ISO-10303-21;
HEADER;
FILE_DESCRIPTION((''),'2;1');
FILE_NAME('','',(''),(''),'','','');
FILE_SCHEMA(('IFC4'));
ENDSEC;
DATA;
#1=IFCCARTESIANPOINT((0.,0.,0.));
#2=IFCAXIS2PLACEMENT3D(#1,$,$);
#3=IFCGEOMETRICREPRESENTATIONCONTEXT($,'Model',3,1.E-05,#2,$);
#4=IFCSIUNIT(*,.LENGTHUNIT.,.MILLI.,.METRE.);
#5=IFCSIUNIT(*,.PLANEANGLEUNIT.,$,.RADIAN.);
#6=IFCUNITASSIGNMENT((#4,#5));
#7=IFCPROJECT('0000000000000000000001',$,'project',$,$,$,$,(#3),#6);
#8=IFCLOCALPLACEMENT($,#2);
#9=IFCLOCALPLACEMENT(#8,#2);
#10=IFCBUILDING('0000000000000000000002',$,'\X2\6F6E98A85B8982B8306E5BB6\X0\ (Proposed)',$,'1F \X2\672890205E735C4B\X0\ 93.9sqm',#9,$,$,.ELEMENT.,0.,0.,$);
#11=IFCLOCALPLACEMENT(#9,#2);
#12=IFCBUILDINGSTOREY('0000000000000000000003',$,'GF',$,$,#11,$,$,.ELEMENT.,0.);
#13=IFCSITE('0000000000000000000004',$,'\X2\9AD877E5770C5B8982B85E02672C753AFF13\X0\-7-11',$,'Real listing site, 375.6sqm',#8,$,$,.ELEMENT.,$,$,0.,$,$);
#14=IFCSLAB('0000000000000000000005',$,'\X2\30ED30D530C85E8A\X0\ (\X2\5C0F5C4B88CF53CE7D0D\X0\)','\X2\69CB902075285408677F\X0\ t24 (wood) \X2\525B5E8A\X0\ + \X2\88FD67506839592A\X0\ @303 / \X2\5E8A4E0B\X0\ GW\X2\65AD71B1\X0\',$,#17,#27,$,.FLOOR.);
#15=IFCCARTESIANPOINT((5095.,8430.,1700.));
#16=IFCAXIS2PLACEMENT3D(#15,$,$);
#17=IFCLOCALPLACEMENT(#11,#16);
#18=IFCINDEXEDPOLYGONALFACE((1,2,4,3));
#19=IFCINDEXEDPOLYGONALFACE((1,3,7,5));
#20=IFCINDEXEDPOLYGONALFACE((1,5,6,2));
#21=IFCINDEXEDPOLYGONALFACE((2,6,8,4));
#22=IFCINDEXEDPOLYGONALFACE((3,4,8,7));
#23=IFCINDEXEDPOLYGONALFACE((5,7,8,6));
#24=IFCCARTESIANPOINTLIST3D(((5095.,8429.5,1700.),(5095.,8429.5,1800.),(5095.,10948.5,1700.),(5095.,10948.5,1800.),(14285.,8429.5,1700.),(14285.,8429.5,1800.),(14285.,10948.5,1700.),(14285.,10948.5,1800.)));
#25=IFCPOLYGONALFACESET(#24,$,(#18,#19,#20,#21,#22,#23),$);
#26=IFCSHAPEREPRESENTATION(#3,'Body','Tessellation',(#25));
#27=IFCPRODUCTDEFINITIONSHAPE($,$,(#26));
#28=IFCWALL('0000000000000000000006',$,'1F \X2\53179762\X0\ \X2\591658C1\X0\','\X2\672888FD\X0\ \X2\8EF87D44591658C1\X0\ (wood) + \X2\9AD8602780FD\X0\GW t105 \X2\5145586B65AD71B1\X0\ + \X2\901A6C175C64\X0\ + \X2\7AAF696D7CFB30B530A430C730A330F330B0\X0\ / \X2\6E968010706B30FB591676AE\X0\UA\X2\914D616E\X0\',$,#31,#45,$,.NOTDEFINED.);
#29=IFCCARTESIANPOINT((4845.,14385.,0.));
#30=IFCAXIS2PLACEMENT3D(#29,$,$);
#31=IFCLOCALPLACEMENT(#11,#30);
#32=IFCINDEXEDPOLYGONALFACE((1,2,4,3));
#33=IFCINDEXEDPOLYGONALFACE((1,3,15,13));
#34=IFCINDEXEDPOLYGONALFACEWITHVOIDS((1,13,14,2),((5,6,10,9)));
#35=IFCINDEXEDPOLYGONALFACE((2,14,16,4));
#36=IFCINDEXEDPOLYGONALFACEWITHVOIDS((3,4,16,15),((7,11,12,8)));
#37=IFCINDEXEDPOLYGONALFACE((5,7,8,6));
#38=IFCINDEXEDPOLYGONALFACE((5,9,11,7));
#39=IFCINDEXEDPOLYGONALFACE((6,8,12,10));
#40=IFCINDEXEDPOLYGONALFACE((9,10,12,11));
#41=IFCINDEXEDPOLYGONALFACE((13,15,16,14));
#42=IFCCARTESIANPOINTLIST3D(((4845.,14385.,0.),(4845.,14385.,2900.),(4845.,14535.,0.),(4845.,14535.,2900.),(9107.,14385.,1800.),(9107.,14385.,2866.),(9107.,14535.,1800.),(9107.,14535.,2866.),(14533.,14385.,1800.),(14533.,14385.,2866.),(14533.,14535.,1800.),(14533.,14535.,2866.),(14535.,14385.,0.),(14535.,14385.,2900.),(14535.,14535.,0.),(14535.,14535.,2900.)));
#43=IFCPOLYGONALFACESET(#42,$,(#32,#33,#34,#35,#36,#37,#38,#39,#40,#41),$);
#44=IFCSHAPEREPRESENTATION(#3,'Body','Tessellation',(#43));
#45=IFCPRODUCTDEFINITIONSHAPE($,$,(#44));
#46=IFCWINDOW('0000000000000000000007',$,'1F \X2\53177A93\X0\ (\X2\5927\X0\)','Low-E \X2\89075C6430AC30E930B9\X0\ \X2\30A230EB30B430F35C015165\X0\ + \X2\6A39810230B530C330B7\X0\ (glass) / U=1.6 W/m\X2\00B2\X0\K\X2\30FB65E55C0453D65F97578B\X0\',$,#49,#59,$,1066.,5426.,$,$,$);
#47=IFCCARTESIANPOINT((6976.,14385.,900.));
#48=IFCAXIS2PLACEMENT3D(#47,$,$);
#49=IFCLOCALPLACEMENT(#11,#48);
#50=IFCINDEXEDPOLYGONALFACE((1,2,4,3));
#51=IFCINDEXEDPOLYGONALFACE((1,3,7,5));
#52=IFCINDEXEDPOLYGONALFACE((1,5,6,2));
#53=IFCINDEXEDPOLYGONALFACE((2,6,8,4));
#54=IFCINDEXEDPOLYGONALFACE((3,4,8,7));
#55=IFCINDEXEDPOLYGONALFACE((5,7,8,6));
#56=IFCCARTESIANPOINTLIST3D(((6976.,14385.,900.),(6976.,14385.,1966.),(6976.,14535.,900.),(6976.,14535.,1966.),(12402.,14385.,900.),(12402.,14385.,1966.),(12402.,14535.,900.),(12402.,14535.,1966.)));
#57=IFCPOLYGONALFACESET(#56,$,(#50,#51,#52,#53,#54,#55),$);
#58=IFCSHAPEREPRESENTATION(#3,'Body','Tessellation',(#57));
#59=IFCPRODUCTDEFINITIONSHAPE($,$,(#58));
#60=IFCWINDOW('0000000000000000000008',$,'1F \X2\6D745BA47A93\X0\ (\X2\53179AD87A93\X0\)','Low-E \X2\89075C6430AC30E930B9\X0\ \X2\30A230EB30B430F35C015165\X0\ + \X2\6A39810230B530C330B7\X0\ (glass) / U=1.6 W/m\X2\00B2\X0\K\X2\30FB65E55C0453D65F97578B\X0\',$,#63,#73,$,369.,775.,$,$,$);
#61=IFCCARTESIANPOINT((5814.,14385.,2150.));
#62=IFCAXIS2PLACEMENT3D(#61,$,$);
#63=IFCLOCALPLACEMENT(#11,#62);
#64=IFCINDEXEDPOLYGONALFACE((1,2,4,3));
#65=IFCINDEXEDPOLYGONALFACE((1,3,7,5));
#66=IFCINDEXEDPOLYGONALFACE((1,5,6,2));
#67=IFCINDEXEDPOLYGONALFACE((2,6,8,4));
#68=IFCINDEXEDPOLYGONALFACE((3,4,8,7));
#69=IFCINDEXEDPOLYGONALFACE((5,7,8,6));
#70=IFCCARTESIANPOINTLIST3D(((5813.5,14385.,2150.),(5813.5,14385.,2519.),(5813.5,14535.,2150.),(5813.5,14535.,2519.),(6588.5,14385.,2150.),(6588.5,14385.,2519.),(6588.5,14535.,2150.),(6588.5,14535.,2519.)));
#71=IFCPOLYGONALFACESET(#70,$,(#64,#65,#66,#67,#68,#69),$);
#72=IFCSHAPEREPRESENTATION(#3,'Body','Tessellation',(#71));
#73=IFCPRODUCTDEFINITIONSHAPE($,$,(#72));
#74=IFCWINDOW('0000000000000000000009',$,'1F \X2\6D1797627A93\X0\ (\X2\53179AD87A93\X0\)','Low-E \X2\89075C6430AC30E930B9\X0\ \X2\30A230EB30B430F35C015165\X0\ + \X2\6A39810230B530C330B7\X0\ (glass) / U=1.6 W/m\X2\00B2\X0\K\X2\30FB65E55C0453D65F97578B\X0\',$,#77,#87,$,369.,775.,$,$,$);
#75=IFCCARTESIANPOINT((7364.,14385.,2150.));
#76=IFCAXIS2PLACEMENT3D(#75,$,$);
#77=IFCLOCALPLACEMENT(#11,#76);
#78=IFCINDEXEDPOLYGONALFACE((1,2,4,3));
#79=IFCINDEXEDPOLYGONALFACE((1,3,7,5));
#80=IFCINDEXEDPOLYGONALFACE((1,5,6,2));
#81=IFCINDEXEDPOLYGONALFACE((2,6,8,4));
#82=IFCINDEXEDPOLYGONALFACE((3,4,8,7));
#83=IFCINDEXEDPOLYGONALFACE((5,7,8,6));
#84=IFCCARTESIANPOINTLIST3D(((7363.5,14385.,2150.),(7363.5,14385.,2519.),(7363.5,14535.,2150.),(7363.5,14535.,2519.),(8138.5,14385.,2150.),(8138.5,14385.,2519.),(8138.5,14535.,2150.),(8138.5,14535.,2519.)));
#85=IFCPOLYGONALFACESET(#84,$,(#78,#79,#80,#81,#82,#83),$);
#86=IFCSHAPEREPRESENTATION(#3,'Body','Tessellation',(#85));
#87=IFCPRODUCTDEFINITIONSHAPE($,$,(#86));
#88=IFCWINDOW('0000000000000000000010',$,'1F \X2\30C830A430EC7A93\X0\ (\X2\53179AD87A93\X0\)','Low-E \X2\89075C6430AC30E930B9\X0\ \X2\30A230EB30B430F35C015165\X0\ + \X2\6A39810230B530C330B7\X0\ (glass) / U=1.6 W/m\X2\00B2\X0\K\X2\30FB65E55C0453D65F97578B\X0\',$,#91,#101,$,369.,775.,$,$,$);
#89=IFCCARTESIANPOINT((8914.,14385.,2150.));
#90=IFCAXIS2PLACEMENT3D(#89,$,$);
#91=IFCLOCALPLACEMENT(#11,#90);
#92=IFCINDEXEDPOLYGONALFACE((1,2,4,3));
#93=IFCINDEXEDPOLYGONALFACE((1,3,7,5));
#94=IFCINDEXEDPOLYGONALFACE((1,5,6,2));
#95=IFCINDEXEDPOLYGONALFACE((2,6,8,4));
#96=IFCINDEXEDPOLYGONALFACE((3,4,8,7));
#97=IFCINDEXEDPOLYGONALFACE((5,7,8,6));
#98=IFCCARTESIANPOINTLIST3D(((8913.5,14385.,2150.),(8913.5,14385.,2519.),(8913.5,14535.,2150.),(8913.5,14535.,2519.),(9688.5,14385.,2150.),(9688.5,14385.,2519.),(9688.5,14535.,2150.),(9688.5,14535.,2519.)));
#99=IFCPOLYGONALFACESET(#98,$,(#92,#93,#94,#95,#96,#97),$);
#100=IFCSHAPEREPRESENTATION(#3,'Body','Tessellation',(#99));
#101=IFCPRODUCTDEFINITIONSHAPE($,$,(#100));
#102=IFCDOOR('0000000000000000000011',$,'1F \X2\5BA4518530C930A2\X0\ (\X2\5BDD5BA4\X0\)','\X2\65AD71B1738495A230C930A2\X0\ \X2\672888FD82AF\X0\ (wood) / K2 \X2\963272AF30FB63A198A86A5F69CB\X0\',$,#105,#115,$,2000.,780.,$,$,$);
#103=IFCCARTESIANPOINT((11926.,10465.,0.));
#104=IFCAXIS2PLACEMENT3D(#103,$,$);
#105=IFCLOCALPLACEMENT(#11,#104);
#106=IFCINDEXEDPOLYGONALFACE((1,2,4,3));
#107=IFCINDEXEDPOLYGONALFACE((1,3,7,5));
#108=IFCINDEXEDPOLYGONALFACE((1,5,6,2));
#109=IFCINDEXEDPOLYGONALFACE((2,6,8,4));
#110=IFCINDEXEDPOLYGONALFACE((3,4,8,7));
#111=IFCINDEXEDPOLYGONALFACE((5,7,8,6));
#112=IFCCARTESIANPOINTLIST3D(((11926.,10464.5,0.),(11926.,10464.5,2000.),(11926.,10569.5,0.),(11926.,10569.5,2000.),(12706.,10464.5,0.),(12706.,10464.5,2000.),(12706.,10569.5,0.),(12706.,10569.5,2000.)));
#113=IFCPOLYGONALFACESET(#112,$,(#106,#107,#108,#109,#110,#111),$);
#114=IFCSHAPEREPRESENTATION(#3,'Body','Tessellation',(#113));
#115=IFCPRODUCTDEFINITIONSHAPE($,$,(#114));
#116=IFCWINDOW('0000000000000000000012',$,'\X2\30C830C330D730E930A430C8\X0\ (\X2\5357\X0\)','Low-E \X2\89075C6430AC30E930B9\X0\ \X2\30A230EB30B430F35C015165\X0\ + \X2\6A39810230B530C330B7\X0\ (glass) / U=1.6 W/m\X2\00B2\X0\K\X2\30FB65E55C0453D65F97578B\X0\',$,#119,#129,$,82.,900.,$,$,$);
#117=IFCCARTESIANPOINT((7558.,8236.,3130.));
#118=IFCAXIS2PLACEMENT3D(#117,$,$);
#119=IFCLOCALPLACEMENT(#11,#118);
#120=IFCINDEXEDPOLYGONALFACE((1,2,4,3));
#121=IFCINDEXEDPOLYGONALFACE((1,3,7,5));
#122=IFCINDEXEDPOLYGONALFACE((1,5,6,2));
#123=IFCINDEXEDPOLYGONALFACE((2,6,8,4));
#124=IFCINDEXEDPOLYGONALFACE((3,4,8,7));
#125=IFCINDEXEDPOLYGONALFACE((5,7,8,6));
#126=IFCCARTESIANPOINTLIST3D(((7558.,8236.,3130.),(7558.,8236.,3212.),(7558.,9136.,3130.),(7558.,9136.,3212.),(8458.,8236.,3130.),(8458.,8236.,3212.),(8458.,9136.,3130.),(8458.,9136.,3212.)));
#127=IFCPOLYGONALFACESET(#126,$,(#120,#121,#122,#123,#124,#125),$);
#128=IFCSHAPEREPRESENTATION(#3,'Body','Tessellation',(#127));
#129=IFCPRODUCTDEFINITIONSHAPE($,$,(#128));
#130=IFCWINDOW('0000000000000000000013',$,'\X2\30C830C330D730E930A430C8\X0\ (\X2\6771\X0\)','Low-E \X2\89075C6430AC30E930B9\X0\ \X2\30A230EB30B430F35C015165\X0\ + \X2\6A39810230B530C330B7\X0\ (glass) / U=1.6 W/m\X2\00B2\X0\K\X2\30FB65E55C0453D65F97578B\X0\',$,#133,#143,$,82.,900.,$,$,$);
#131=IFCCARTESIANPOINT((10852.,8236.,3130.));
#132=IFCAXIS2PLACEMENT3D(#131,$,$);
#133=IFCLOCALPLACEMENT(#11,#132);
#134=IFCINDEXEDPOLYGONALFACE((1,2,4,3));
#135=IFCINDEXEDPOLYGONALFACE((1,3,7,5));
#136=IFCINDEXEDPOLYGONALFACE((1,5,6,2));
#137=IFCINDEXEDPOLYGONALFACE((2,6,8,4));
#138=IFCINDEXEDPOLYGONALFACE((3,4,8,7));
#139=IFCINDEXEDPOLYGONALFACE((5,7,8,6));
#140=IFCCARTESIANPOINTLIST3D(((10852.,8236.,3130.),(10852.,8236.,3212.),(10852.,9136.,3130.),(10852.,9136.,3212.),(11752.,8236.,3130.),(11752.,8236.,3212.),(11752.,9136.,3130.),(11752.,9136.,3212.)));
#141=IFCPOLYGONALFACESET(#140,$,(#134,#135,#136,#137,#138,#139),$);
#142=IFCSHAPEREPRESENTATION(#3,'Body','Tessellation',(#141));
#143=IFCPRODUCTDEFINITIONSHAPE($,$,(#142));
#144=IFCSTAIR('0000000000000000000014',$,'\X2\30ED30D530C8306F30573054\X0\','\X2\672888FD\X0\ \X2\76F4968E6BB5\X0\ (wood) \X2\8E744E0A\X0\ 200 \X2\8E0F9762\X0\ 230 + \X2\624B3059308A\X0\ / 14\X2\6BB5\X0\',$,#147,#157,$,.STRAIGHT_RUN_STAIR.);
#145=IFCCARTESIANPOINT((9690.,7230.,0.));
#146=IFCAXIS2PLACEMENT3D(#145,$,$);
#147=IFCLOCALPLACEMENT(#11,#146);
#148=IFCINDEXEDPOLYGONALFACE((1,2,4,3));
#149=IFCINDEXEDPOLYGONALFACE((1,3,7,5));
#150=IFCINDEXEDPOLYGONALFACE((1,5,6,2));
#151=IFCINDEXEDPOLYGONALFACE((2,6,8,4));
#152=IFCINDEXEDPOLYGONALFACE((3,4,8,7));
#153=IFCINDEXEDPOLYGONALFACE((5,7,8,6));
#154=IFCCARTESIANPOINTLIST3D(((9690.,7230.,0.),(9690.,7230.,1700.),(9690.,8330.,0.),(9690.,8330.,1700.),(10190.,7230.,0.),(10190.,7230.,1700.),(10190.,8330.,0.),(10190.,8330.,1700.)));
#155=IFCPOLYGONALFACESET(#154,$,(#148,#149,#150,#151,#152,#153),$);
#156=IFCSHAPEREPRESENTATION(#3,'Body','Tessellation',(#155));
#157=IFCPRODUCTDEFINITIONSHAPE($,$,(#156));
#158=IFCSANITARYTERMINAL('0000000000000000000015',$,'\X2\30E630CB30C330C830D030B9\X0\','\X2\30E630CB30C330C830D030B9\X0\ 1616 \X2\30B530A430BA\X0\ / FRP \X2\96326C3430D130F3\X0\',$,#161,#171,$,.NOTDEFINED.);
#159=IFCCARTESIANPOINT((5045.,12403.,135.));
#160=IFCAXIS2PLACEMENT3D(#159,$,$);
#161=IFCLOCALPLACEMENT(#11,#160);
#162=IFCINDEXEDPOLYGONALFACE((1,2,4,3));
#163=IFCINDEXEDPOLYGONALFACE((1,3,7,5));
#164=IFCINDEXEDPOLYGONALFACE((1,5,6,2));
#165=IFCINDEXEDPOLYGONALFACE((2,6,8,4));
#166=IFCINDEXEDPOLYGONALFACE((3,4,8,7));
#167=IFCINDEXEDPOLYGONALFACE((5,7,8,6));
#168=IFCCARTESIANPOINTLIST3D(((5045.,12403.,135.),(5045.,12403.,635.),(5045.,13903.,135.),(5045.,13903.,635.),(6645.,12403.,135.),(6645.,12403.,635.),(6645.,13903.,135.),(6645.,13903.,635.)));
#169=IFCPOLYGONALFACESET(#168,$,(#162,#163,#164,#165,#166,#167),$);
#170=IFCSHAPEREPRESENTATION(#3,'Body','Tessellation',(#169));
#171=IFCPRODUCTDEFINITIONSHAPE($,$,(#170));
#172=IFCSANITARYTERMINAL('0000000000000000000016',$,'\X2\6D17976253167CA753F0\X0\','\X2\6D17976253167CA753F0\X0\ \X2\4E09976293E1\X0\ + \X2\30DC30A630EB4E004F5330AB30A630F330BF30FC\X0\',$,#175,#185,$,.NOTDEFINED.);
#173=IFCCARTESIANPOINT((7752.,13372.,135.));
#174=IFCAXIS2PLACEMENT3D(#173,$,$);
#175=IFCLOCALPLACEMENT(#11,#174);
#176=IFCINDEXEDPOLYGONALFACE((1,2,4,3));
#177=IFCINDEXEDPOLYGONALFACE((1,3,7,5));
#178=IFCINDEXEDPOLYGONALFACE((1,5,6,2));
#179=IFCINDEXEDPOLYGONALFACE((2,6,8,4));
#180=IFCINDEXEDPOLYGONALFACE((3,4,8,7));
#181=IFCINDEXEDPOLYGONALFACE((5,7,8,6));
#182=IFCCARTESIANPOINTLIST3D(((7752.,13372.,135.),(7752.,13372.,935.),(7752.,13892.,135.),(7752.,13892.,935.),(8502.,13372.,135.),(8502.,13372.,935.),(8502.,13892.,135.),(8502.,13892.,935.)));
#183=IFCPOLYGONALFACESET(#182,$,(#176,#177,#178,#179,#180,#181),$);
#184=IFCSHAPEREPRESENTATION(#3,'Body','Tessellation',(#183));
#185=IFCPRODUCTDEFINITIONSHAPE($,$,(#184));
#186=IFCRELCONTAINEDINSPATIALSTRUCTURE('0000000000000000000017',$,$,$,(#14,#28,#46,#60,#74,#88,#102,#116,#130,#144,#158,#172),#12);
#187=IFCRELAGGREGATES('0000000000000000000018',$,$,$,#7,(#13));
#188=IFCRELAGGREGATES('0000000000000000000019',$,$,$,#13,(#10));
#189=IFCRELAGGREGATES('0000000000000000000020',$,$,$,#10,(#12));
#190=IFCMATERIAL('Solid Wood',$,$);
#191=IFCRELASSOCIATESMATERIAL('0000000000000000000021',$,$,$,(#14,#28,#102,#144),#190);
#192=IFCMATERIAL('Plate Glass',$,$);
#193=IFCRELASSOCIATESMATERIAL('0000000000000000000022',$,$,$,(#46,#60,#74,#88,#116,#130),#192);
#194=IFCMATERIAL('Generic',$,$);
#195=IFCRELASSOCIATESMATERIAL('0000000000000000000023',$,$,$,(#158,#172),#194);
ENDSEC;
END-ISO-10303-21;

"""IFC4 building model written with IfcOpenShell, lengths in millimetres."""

from ifc_helpers import new_model, si_unit, frame, frame_2d, origin, place, context, project, spatial, rectangle, extrude, material, element, fill, save


model = new_model("IFC4")

# Units and contexts
model_context = context("Model", 3, precision=1e-05, world=origin())
ifc_project = project(units=[si_unit("LENGTHUNIT", "METRE", prefix="MILLI"), si_unit("PLANEANGLEUNIT", "RADIAN")], contexts=[model_context])

# Site, building, storey
site_placement = place(None, origin())
site = spatial("IfcSite", under=ifc_project, at=site_placement, Name="高知県安芸市本町３-7-11", ObjectType="Real listing site, 375.6sqm", CompositionType="ELEMENT", RefElevation=0.0)
building_placement = place(site_placement, origin())
building = spatial("IfcBuilding", under=site, at=building_placement, Name="潮風安芸の家 (Proposed)", ObjectType="1F 木造平屋 93.9sqm", CompositionType="ELEMENT", ElevationOfRefHeight=0.0, ElevationOfTerrain=0.0)
storey_placement = place(building_placement, origin())
storey = spatial("IfcBuildingStorey", under=building, at=storey_placement, Name="GF", CompositionType="ELEMENT", Elevation=0.0)

# Slab
ifc_material_1 = material(Name="Solid Wood")
slab_placement = place(storey_placement, frame((5095.0, 8430.0, 1700.0)))
element("IfcSlab", 1, at=slab_placement, inside=storey, material=ifc_material_1, Name="ロフト床 (小屋裏収納)", Description="構造用合板 t24 (wood) 剛床 + 製材根太 @303 / 床下 GW断熱", PredefinedType="FLOOR", context=model_context, shape_type="SweptSolid", body=[
    extrude(rectangle(XDim=9190.0, YDim=2519.0, at=frame_2d((4595.0, 1259.0))), frame((5095.0, 8430.0, 1700.0)), (0.0, 0.0, 1.0), 100.0),
])

# Wall, openings, windows
wall_1_placement = place(storey_placement, frame((4845.0, 14385.0, 0.0)))
wall_1 = element("IfcWall", 2, at=wall_1_placement, inside=storey, material=ifc_material_1, Name="1F 北面 外壁", Description="木製 軸組外壁 (wood) + 高性能GW t105 充填断熱 + 通気層 + 窯業系サイディング / 準耐火・外皮UA配慮", PredefinedType="NOTDEFINED", context=model_context, shape_type="SweptSolid", body=[
    extrude(rectangle(XDim=9690.0, YDim=150.0, at=frame_2d((4845.0, 75.0))), frame((4845.0, 14385.0, 0.0)), (0.0, 0.0, 1.0), 2900.0),
])
opening_1_placement = place(storey_placement, frame((6976.0, 14385.0, 900.0)))
opening_1 = element("IfcOpeningElement", 3, at=opening_1_placement, cuts=wall_1, PredefinedType="NOTDEFINED", context=model_context, shape_type="SweptSolid", body=[
    extrude(rectangle(XDim=5426.0, YDim=150.0, at=frame_2d((2713.0, 75.0))), frame((6976.0, 14385.0, 900.0)), (0.0, 0.0, 1.0), 1066.0),
])
opening_2_placement = place(storey_placement, frame((5814.0, 14385.0, 2150.0)))
opening_2 = element("IfcOpeningElement", 4, at=opening_2_placement, cuts=wall_1, PredefinedType="NOTDEFINED", context=model_context, shape_type="SweptSolid", body=[
    extrude(rectangle(XDim=775.0, YDim=150.0, at=frame_2d((387.0, 75.0))), frame((5814.0, 14385.0, 2150.0)), (0.0, 0.0, 1.0), 369.0),
])
opening_3_placement = place(storey_placement, frame((7364.0, 14385.0, 2150.0)))
opening_3 = element("IfcOpeningElement", 5, at=opening_3_placement, cuts=wall_1, PredefinedType="NOTDEFINED", context=model_context, shape_type="SweptSolid", body=[
    extrude(rectangle(XDim=775.0, YDim=150.0, at=frame_2d((387.0, 75.0))), frame((7364.0, 14385.0, 2150.0)), (0.0, 0.0, 1.0), 369.0),
])
opening_4_placement = place(storey_placement, frame((8914.0, 14385.0, 2150.0)))
opening_4 = element("IfcOpeningElement", 6, at=opening_4_placement, cuts=wall_1, PredefinedType="NOTDEFINED", context=model_context, shape_type="SweptSolid", body=[
    extrude(rectangle(XDim=775.0, YDim=150.0, at=frame_2d((387.0, 75.0))), frame((8914.0, 14385.0, 2150.0)), (0.0, 0.0, 1.0), 369.0),
])
ifc_material_2 = material(Name="Plate Glass")
window_1_placement = place(storey_placement, frame((6976.0, 14385.0, 900.0)))
window_1 = element("IfcWindow", 7, at=window_1_placement, inside=storey, material=ifc_material_2, Name="1F 北窓 (大)", Description="Low-E 複層ガラス アルゴン封入 + 樹脂サッシ (glass) / U=1.6 W/m²K・日射取得型", OverallHeight=1066.0, OverallWidth=5426.0, context=model_context, shape_type="SweptSolid", body=[
    extrude(rectangle(XDim=5426.0, YDim=150.0, at=frame_2d((2713.0, 75.0))), frame((6976.0, 14385.0, 900.0)), (0.0, 0.0, 1.0), 1066.0),
])
fill(opening_1, window_1)
window_2_placement = place(storey_placement, frame((5814.0, 14385.0, 2150.0)))
window_2 = element("IfcWindow", 8, at=window_2_placement, inside=storey, material=ifc_material_2, Name="1F 浴室窓 (北高窓)", Description="Low-E 複層ガラス アルゴン封入 + 樹脂サッシ (glass) / U=1.6 W/m²K・日射取得型", OverallHeight=369.0, OverallWidth=775.0, context=model_context, shape_type="SweptSolid", body=[
    extrude(rectangle(XDim=775.0, YDim=150.0, at=frame_2d((387.0, 75.0))), frame((5814.0, 14385.0, 2150.0)), (0.0, 0.0, 1.0), 369.0),
])
fill(opening_2, window_2)
window_3_placement = place(storey_placement, frame((7364.0, 14385.0, 2150.0)))
window_3 = element("IfcWindow", 9, at=window_3_placement, inside=storey, material=ifc_material_2, Name="1F 洗面窓 (北高窓)", Description="Low-E 複層ガラス アルゴン封入 + 樹脂サッシ (glass) / U=1.6 W/m²K・日射取得型", OverallHeight=369.0, OverallWidth=775.0, context=model_context, shape_type="SweptSolid", body=[
    extrude(rectangle(XDim=775.0, YDim=150.0, at=frame_2d((387.0, 75.0))), frame((7364.0, 14385.0, 2150.0)), (0.0, 0.0, 1.0), 369.0),
])
fill(opening_3, window_3)
window_4_placement = place(storey_placement, frame((8914.0, 14385.0, 2150.0)))
window_4 = element("IfcWindow", 10, at=window_4_placement, inside=storey, material=ifc_material_2, Name="1F トイレ窓 (北高窓)", Description="Low-E 複層ガラス アルゴン封入 + 樹脂サッシ (glass) / U=1.6 W/m²K・日射取得型", OverallHeight=369.0, OverallWidth=775.0, context=model_context, shape_type="SweptSolid", body=[
    extrude(rectangle(XDim=775.0, YDim=150.0, at=frame_2d((387.0, 75.0))), frame((8914.0, 14385.0, 2150.0)), (0.0, 0.0, 1.0), 369.0),
])
fill(opening_4, window_4)

# Door
door_1_placement = place(storey_placement, frame((11926.0, 10465.0, 0.0)))
element("IfcDoor", 11, at=door_1_placement, inside=storey, material=ifc_material_1, Name="1F 室内ドア (寝室)", Description="断熱玄関ドア 木製芯 (wood) / K2 防犯・採風機構", OverallHeight=2000.0, OverallWidth=780.0, context=model_context, shape_type="SweptSolid", body=[
    extrude(rectangle(XDim=780.0, YDim=105.0, at=frame_2d((390.0, 52.0))), frame((11926.0, 10465.0, 0.0)), (0.0, 0.0, 1.0), 2000.0),
])

# Windows
window_5_placement = place(storey_placement, frame((7558.0, 8236.0, 3130.0)))
element("IfcWindow", 12, at=window_5_placement, inside=storey, material=ifc_material_2, Name="トップライト (南)", Description="Low-E 複層ガラス アルゴン封入 + 樹脂サッシ (glass) / U=1.6 W/m²K・日射取得型", OverallHeight=82.0, OverallWidth=900.0, context=model_context, shape_type="SweptSolid", body=[
    extrude(rectangle(XDim=900.0, YDim=900.0, at=frame_2d((450.0, 450.0))), frame((7558.0, 8236.0, 3130.0)), (0.0, 0.0, 1.0), 82.0),
])
window_6_placement = place(storey_placement, frame((10852.0, 8236.0, 3130.0)))
element("IfcWindow", 13, at=window_6_placement, inside=storey, material=ifc_material_2, Name="トップライト (東)", Description="Low-E 複層ガラス アルゴン封入 + 樹脂サッシ (glass) / U=1.6 W/m²K・日射取得型", OverallHeight=82.0, OverallWidth=900.0, context=model_context, shape_type="SweptSolid", body=[
    extrude(rectangle(XDim=900.0, YDim=900.0, at=frame_2d((450.0, 450.0))), frame((10852.0, 8236.0, 3130.0)), (0.0, 0.0, 1.0), 82.0),
])

# Stair
stair_placement = place(storey_placement, frame((9690.0, 7230.0, 0.0)))
element("IfcStair", 14, at=stair_placement, inside=storey, material=ifc_material_1, Name="ロフトはしご", Description="木製 直階段 (wood) 蹴上 200 踏面 230 + 手すり / 14段", PredefinedType="STRAIGHT_RUN_STAIR", context=model_context, shape_type="SweptSolid", body=[
    extrude(rectangle(XDim=500.0, YDim=1100.0, at=frame_2d((250.0, 550.0))), frame((9690.0, 7230.0, 0.0)), (0.0, 0.0, 1.0), 1700.0),
])

# Sanitary terminals
ifc_material_3 = material(Name="Generic")
sanitary_terminal_1_placement = place(storey_placement, frame((5045.0, 12403.0, 135.0)))
element("IfcSanitaryTerminal", 15, at=sanitary_terminal_1_placement, inside=storey, material=ifc_material_3, Name="ユニットバス", Description="ユニットバス 1616 サイズ / FRP 防水パン", PredefinedType="NOTDEFINED", context=model_context, shape_type="SweptSolid", body=[
    extrude(rectangle(XDim=1600.0, YDim=1500.0, at=frame_2d((800.0, 750.0))), frame((5045.0, 12403.0, 135.0)), (0.0, 0.0, 1.0), 500.0),
])
sanitary_terminal_2_placement = place(storey_placement, frame((7752.0, 13372.0, 135.0)))
element("IfcSanitaryTerminal", 16, at=sanitary_terminal_2_placement, inside=storey, material=ifc_material_3, Name="洗面化粧台", Description="洗面化粧台 三面鏡 + ボウル一体カウンター", PredefinedType="NOTDEFINED", context=model_context, shape_type="SweptSolid", body=[
    extrude(rectangle(XDim=750.0, YDim=520.0, at=frame_2d((375.0, 260.0))), frame((7752.0, 13372.0, 135.0)), (0.0, 0.0, 1.0), 800.0),
])

save(model, "model.ifc")
